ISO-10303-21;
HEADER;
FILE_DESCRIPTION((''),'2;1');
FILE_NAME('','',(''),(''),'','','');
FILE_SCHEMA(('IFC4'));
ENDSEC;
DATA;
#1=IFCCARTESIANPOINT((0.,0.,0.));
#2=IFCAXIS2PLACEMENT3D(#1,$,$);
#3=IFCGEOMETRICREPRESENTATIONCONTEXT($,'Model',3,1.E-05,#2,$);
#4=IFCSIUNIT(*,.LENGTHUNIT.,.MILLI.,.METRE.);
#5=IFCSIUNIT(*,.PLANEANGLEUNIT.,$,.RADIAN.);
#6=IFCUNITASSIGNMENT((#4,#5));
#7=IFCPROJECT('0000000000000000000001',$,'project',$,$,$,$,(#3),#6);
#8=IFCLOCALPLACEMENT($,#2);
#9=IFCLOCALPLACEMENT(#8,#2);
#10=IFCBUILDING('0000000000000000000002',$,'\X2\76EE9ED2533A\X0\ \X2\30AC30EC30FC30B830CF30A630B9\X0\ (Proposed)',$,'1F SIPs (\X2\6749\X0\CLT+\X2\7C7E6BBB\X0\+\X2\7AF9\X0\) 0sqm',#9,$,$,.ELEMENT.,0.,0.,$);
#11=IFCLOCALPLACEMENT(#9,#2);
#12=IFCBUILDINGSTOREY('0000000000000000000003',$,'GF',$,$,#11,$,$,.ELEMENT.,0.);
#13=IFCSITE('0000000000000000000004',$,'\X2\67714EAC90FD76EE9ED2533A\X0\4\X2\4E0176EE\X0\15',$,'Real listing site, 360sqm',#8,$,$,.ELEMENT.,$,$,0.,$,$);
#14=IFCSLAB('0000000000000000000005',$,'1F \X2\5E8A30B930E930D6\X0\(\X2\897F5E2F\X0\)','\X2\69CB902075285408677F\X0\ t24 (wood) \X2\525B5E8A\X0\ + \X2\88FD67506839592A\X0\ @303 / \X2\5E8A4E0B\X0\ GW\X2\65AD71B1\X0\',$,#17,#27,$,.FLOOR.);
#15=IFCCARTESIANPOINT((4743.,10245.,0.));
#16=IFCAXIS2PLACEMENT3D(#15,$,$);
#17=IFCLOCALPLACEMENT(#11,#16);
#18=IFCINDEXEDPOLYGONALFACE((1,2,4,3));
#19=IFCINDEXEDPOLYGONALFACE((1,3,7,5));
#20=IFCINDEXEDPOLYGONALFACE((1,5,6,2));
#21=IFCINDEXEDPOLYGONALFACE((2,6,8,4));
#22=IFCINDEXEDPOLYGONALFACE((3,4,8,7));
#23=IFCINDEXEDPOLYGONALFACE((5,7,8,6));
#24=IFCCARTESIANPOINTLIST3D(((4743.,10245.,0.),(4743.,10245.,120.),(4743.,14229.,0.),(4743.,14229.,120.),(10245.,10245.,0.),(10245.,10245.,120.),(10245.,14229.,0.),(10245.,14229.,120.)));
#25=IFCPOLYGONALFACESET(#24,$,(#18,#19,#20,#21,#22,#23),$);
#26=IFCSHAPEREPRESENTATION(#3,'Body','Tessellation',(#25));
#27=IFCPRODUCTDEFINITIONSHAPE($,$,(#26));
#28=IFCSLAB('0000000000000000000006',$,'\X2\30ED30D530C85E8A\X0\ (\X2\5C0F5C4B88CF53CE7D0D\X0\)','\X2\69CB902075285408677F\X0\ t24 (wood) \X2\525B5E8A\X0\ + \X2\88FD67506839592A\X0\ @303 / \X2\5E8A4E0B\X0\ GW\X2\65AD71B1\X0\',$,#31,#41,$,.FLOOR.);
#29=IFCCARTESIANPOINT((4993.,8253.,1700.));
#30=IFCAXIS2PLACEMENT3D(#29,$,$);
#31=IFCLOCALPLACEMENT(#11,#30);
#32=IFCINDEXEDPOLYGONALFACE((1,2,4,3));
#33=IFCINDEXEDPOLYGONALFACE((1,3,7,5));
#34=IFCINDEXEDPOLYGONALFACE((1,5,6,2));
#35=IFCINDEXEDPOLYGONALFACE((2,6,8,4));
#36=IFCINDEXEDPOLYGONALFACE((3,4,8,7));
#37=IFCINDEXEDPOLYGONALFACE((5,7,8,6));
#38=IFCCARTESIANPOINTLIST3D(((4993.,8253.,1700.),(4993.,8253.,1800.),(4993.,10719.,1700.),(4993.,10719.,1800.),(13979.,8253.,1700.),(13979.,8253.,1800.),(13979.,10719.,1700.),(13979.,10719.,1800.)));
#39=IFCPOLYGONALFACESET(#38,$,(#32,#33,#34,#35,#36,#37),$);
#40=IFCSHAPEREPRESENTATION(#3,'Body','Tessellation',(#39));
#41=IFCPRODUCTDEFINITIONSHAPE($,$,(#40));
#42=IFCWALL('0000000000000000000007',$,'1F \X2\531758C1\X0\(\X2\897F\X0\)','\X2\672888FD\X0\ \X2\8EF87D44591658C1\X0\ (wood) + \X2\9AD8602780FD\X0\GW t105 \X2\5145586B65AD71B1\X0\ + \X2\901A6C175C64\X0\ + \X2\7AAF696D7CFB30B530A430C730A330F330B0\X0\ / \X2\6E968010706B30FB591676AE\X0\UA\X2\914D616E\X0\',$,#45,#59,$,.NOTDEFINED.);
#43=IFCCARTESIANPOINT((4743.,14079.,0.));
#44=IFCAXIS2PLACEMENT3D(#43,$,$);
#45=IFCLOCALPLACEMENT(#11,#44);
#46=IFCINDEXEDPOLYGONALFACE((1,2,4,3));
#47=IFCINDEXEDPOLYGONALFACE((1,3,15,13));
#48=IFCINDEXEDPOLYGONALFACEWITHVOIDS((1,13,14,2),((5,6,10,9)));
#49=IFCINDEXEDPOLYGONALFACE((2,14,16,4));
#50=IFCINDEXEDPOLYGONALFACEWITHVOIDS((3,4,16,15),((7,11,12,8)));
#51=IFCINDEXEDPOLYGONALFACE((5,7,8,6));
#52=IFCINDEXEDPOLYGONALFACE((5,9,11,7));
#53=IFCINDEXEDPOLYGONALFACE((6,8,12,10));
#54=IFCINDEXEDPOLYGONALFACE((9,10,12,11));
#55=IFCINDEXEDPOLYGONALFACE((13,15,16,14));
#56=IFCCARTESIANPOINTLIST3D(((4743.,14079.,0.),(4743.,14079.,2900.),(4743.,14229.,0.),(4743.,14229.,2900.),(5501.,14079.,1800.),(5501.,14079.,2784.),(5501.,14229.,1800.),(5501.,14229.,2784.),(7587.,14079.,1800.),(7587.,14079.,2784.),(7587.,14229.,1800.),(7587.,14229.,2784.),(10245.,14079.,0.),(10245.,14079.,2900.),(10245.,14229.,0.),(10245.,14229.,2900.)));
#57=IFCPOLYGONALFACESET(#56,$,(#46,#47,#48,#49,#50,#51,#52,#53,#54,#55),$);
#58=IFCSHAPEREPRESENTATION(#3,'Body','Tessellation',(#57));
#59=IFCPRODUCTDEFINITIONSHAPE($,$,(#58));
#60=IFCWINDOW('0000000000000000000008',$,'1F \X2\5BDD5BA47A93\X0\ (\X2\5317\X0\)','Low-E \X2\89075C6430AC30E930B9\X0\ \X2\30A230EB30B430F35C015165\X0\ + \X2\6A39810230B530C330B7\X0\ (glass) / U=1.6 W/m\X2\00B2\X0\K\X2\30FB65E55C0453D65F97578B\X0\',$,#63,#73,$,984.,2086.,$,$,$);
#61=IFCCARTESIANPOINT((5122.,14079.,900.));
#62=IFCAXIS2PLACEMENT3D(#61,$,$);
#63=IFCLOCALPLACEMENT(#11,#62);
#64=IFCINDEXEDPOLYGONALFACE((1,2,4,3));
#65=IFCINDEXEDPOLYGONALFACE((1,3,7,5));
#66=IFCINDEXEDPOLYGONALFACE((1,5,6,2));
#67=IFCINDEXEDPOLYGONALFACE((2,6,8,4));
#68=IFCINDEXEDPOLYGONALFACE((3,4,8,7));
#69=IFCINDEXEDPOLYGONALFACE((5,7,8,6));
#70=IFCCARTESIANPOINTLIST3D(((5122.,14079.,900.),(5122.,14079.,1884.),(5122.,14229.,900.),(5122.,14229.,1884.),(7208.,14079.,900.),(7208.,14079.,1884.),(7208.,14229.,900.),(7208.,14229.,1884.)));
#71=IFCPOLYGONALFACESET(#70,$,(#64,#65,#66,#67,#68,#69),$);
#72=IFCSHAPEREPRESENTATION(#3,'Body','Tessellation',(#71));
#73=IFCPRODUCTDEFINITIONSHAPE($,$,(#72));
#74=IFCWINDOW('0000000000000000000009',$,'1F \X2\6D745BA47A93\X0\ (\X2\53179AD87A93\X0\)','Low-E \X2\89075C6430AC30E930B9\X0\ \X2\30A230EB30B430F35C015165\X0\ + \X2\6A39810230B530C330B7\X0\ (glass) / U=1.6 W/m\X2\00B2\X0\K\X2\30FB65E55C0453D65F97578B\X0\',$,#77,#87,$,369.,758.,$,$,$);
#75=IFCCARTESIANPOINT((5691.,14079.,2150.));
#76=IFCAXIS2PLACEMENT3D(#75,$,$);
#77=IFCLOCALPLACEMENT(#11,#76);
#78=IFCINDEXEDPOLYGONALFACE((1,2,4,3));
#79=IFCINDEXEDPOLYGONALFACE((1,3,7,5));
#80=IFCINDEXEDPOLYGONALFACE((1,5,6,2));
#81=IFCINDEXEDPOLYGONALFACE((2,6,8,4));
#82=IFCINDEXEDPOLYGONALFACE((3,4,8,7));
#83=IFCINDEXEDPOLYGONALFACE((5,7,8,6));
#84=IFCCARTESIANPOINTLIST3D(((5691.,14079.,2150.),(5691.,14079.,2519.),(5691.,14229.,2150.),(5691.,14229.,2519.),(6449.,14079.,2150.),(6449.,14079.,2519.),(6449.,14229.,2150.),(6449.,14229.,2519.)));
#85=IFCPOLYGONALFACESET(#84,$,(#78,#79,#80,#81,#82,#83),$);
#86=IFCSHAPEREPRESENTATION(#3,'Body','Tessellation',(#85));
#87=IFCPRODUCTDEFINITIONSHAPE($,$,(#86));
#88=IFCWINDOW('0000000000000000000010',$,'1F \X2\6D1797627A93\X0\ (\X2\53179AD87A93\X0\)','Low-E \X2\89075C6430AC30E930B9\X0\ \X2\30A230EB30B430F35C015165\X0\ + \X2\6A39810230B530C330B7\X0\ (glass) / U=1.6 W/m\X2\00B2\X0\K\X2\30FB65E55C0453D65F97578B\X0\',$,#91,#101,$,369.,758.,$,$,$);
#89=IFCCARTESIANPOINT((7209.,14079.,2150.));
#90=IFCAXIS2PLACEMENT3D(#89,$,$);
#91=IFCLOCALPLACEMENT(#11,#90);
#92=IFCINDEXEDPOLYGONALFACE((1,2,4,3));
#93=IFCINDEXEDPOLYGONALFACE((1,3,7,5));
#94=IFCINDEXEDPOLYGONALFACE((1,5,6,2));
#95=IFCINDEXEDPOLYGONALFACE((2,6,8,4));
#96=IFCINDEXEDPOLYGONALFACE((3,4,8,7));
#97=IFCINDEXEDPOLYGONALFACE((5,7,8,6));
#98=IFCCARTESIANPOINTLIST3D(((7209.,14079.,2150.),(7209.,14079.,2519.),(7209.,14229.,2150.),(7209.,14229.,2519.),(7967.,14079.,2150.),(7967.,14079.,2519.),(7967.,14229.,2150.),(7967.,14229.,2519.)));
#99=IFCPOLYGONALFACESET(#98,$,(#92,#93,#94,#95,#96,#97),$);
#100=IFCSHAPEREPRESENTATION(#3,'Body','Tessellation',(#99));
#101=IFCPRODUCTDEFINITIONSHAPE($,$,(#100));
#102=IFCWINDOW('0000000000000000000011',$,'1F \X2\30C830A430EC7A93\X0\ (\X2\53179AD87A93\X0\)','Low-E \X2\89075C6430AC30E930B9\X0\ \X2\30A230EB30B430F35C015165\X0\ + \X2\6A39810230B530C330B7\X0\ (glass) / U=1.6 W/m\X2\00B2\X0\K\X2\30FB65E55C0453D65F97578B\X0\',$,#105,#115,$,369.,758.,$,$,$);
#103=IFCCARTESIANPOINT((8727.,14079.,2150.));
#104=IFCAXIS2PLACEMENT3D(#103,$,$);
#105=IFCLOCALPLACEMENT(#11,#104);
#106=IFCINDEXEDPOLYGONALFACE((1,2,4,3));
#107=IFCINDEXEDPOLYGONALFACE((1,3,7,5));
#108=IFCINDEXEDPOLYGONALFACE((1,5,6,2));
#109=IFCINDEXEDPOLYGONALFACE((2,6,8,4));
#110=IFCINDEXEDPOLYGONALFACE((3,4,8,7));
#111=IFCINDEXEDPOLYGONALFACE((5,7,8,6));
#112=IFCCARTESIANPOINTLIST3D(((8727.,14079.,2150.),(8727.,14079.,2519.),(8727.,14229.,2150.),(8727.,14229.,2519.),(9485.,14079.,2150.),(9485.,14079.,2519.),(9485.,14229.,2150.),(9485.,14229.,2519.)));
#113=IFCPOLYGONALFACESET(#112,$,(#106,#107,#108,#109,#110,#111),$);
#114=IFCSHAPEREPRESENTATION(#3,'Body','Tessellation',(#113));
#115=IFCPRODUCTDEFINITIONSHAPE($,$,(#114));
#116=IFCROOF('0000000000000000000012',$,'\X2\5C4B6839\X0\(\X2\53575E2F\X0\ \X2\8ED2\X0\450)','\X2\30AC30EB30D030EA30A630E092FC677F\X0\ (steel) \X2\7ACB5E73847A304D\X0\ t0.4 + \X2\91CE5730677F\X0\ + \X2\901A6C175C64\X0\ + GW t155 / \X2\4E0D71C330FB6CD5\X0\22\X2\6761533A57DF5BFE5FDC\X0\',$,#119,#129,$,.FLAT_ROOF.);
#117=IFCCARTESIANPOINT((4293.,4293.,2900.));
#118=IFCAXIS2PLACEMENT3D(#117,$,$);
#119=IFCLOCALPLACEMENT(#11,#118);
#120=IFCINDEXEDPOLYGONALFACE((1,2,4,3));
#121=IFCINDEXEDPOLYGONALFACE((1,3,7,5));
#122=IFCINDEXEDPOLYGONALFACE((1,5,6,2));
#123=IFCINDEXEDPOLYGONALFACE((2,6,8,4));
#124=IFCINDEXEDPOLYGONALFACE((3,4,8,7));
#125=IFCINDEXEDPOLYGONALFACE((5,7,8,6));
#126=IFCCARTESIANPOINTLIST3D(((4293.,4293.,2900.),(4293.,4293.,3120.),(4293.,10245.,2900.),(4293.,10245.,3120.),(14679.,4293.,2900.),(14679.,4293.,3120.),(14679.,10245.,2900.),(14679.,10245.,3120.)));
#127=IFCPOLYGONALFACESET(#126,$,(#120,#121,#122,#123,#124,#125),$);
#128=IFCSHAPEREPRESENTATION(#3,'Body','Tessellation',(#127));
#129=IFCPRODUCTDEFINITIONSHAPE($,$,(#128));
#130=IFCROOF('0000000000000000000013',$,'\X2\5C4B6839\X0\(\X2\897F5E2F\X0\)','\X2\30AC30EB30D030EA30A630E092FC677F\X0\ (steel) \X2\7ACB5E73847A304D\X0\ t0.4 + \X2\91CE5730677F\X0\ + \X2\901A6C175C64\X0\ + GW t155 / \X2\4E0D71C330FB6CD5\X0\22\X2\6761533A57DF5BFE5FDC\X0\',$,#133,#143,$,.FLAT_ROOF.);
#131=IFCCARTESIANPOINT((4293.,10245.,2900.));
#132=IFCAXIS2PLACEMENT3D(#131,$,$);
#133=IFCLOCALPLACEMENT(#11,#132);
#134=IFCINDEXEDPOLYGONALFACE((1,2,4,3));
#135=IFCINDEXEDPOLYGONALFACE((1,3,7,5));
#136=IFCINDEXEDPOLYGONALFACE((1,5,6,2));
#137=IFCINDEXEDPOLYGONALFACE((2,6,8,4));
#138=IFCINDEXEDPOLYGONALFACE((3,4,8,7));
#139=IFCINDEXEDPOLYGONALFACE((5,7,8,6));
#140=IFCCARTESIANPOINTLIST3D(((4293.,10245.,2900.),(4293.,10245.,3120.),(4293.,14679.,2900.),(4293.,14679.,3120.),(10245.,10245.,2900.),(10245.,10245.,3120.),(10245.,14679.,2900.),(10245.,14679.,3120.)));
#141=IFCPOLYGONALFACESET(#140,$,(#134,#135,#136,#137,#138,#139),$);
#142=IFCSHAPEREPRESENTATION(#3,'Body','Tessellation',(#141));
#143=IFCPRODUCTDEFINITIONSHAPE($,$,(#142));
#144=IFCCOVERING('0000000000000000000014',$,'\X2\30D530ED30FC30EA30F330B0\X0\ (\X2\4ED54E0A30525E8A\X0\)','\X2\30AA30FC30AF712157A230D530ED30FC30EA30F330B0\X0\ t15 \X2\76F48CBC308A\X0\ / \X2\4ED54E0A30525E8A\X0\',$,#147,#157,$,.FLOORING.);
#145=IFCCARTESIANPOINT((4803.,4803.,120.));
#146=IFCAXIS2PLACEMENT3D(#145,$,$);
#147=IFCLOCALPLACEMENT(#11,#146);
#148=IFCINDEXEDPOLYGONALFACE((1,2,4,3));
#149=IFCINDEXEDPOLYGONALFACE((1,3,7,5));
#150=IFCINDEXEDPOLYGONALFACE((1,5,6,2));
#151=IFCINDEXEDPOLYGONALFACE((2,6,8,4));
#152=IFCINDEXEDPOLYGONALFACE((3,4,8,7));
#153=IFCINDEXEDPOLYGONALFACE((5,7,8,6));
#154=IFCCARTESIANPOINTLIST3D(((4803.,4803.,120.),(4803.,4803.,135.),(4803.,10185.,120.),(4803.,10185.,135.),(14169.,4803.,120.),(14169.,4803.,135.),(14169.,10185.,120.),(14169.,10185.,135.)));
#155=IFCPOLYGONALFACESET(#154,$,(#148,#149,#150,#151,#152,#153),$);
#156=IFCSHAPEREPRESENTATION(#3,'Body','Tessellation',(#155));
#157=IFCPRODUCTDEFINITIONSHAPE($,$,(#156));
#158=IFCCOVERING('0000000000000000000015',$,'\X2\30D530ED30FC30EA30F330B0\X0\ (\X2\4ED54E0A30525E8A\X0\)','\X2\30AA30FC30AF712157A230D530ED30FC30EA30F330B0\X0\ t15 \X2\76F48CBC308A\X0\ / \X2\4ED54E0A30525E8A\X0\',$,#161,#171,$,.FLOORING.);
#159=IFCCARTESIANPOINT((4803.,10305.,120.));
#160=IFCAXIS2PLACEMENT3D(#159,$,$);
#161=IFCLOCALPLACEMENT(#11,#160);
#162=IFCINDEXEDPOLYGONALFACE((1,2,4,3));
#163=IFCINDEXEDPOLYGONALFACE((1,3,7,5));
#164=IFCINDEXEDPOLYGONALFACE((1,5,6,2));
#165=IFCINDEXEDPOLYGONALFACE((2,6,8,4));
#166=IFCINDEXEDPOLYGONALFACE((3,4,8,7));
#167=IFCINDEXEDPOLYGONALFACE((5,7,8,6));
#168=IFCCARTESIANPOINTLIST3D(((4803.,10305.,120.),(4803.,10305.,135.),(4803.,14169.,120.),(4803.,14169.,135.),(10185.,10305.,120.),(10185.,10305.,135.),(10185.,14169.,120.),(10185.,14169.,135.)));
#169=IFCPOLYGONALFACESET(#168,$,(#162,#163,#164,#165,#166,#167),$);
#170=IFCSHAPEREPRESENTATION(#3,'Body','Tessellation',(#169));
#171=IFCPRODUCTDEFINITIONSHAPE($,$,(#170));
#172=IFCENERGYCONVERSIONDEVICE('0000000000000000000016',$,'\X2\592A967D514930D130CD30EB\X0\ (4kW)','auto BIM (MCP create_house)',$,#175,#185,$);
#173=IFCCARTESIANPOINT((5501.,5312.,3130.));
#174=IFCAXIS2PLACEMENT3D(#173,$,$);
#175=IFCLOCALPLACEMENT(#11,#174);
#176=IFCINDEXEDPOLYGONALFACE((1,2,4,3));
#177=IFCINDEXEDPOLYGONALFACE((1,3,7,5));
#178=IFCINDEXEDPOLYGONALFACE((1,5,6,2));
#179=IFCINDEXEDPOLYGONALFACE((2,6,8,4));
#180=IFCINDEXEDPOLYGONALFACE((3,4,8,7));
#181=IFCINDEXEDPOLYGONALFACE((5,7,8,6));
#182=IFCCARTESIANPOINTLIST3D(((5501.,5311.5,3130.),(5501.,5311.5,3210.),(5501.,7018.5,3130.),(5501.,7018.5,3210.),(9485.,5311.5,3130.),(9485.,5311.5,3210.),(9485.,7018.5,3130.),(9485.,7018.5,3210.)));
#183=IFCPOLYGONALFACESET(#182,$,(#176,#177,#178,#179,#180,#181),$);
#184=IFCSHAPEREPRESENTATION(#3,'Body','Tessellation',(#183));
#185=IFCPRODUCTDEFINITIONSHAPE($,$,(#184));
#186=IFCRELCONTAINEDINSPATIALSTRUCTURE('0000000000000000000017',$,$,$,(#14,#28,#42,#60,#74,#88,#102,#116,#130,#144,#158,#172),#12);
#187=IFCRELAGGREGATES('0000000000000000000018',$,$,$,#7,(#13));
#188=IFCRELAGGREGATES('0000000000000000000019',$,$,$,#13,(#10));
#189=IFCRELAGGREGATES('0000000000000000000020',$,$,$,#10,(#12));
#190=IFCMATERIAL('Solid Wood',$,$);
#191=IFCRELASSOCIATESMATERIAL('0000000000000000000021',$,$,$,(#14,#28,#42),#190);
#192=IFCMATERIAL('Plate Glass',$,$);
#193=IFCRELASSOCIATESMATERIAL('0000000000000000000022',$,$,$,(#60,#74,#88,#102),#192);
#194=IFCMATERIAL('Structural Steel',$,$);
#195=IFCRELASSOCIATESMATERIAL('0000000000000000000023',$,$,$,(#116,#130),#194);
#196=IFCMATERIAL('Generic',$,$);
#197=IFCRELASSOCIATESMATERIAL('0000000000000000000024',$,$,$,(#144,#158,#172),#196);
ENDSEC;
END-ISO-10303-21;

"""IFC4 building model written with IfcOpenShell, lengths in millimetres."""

from ifc_helpers import new_model, si_unit, frame, frame_2d, origin, place, context, project, spatial, rectangle, extrude, material, element, fill, save


model = new_model("IFC4")

# Units and contexts
model_context = context("Model", 3, precision=1e-05, world=origin())
ifc_project = project(units=[si_unit("LENGTHUNIT", "METRE", prefix="MILLI"), si_unit("PLANEANGLEUNIT", "RADIAN")], contexts=[model_context])

# Site, building, storey
site_placement = place(None, origin())
site = spatial("IfcSite", under=ifc_project, at=site_placement, Name="東京都目黒区4丁目15", ObjectType="Real listing site, 360sqm", CompositionType="ELEMENT", RefElevation=0.0)
building_placement = place(site_placement, origin())
building = spatial("IfcBuilding", under=site, at=building_placement, Name="目黒区 ガレージハウス (Proposed)", ObjectType="1F SIPs (杉CLT+籾殻+竹) 0sqm", CompositionType="ELEMENT", ElevationOfRefHeight=0.0, ElevationOfTerrain=0.0)
storey_placement = place(building_placement, origin())
storey = spatial("IfcBuildingStorey", under=building, at=storey_placement, Name="GF", CompositionType="ELEMENT", Elevation=0.0)

# Slabs
ifc_material_1 = material(Name="Solid Wood")
slab_1_placement = place(storey_placement, frame((4743.0, 10245.0, 0.0)))
element("IfcSlab", 1, at=slab_1_placement, inside=storey, material=ifc_material_1, Name="1F 床スラブ(西帯)", Description="構造用合板 t24 (wood) 剛床 + 製材根太 @303 / 床下 GW断熱", PredefinedType="FLOOR", context=model_context, shape_type="SweptSolid", body=[
    extrude(rectangle(XDim=5502.0, YDim=3984.0, at=frame_2d((2751.0, 1992.0))), frame((4743.0, 10245.0, 0.0)), (0.0, 0.0, 1.0), 120.0),
])
slab_2_placement = place(storey_placement, frame((4993.0, 8253.0, 1700.0)))
element("IfcSlab", 2, at=slab_2_placement, inside=storey, material=ifc_material_1, Name="ロフト床 (小屋裏収納)", Description="構造用合板 t24 (wood) 剛床 + 製材根太 @303 / 床下 GW断熱", PredefinedType="FLOOR", context=model_context, shape_type="SweptSolid", body=[
    extrude(rectangle(XDim=8986.0, YDim=2466.0, at=frame_2d((4493.0, 1233.0))), frame((4993.0, 8253.0, 1700.0)), (0.0, 0.0, 1.0), 100.0),
])

# Shared definitions
ifc_material_2 = material(Name="Plate Glass")

# Wall, openings, windows
wall_1_placement = place(storey_placement, frame((4743.0, 14079.0, 0.0)))
wall_1 = element("IfcWall", 3, at=wall_1_placement, inside=storey, material=ifc_material_1, Name="1F 北壁(西)", Description="木製 軸組外壁 (wood) + 高性能GW t105 充填断熱 + 通気層 + 窯業系サイディング / 準耐火・外皮UA配慮", PredefinedType="NOTDEFINED", context=model_context, shape_type="SweptSolid", body=[
    extrude(rectangle(XDim=5502.0, YDim=150.0, at=frame_2d((2751.0, 75.0))), frame((4743.0, 14079.0, 0.0)), (0.0, 0.0, 1.0), 2900.0),
])
opening_1_placement = place(storey_placement, frame((5122.0, 14079.0, 900.0)))
opening_1 = element("IfcOpeningElement", 4, at=opening_1_placement, cuts=wall_1, PredefinedType="NOTDEFINED", context=model_context, shape_type="SweptSolid", body=[
    extrude(rectangle(XDim=2086.0, YDim=150.0, at=frame_2d((1043.0, 75.0))), frame((5122.0, 14079.0, 900.0)), (0.0, 0.0, 1.0), 984.0),
])
opening_2_placement = place(storey_placement, frame((5691.0, 14079.0, 2150.0)))
opening_2 = element("IfcOpeningElement", 5, at=opening_2_placement, cuts=wall_1, PredefinedType="NOTDEFINED", context=model_context, shape_type="SweptSolid", body=[
    extrude(rectangle(XDim=758.0, YDim=150.0, at=frame_2d((379.0, 75.0))), frame((5691.0, 14079.0, 2150.0)), (0.0, 0.0, 1.0), 369.0),
])
opening_3_placement = place(storey_placement, frame((7209.0, 14079.0, 2150.0)))
opening_3 = element("IfcOpeningElement", 6, at=opening_3_placement, cuts=wall_1, PredefinedType="NOTDEFINED", context=model_context, shape_type="SweptSolid", body=[
    extrude(rectangle(XDim=758.0, YDim=150.0, at=frame_2d((379.0, 75.0))), frame((7209.0, 14079.0, 2150.0)), (0.0, 0.0, 1.0), 369.0),
])
opening_4_placement = place(storey_placement, frame((8727.0, 14079.0, 2150.0)))
opening_4 = element("IfcOpeningElement", 7, at=opening_4_placement, cuts=wall_1, PredefinedType="NOTDEFINED", context=model_context, shape_type="SweptSolid", body=[
    extrude(rectangle(XDim=758.0, YDim=150.0, at=frame_2d((379.0, 75.0))), frame((8727.0, 14079.0, 2150.0)), (0.0, 0.0, 1.0), 369.0),
])
window_1_placement = place(storey_placement, frame((5122.0, 14079.0, 900.0)))
window_1 = element("IfcWindow", 8, at=window_1_placement, inside=storey, material=ifc_material_2, Name="1F 寝室窓 (北)", Description="Low-E 複層ガラス アルゴン封入 + 樹脂サッシ (glass) / U=1.6 W/m²K・日射取得型", OverallHeight=984.0, OverallWidth=2086.0, context=model_context, shape_type="SweptSolid", body=[
    extrude(rectangle(XDim=2086.0, YDim=150.0, at=frame_2d((1043.0, 75.0))), frame((5122.0, 14079.0, 900.0)), (0.0, 0.0, 1.0), 984.0),
])
fill(opening_1, window_1)
window_2_placement = place(storey_placement, frame((5691.0, 14079.0, 2150.0)))
window_2 = element("IfcWindow", 9, at=window_2_placement, inside=storey, material=ifc_material_2, Name="1F 浴室窓 (北高窓)", Description="Low-E 複層ガラス アルゴン封入 + 樹脂サッシ (glass) / U=1.6 W/m²K・日射取得型", OverallHeight=369.0, OverallWidth=758.0, context=model_context, shape_type="SweptSolid", body=[
    extrude(rectangle(XDim=758.0, YDim=150.0, at=frame_2d((379.0, 75.0))), frame((5691.0, 14079.0, 2150.0)), (0.0, 0.0, 1.0), 369.0),
])
fill(opening_2, window_2)
window_3_placement = place(storey_placement, frame((7209.0, 14079.0, 2150.0)))
window_3 = element("IfcWindow", 10, at=window_3_placement, inside=storey, material=ifc_material_2, Name="1F 洗面窓 (北高窓)", Description="Low-E 複層ガラス アルゴン封入 + 樹脂サッシ (glass) / U=1.6 W/m²K・日射取得型", OverallHeight=369.0, OverallWidth=758.0, context=model_context, shape_type="SweptSolid", body=[
    extrude(rectangle(XDim=758.0, YDim=150.0, at=frame_2d((379.0, 75.0))), frame((7209.0, 14079.0, 2150.0)), (0.0, 0.0, 1.0), 369.0),
])
fill(opening_3, window_3)
window_4_placement = place(storey_placement, frame((8727.0, 14079.0, 2150.0)))
window_4 = element("IfcWindow", 11, at=window_4_placement, inside=storey, material=ifc_material_2, Name="1F トイレ窓 (北高窓)", Description="Low-E 複層ガラス アルゴン封入 + 樹脂サッシ (glass) / U=1.6 W/m²K・日射取得型", OverallHeight=369.0, OverallWidth=758.0, context=model_context, shape_type="SweptSolid", body=[
    extrude(rectangle(XDim=758.0, YDim=150.0, at=frame_2d((379.0, 75.0))), frame((8727.0, 14079.0, 2150.0)), (0.0, 0.0, 1.0), 369.0),
])
fill(opening_4, window_4)

# Roofs
ifc_material_3 = material(Name="Structural Steel")
roof_1_placement = place(storey_placement, frame((4293.0, 4293.0, 2900.0)))
element("IfcRoof", 12, at=roof_1_placement, inside=storey, material=ifc_material_3, Name="屋根(南帯 軒450)", Description="ガルバリウム鋼板 (steel) 立平葺き t0.4 + 野地板 + 通気層 + GW t155 / 不燃・法22条区域対応", PredefinedType="FLAT_ROOF", context=model_context, shape_type="SweptSolid", body=[
    extrude(rectangle(XDim=10386.0, YDim=5952.0, at=frame_2d((5193.0, 2976.0))), frame((4293.0, 4293.0, 2900.0)), (0.0, 0.0, 1.0), 220.0),
])
roof_2_placement = place(storey_placement, frame((4293.0, 10245.0, 2900.0)))
element("IfcRoof", 13, at=roof_2_placement, inside=storey, material=ifc_material_3, Name="屋根(西帯)", Description="ガルバリウム鋼板 (steel) 立平葺き t0.4 + 野地板 + 通気層 + GW t155 / 不燃・法22条区域対応", PredefinedType="FLAT_ROOF", context=model_context, shape_type="SweptSolid", body=[
    extrude(rectangle(XDim=5952.0, YDim=4434.0, at=frame_2d((2976.0, 2217.0))), frame((4293.0, 10245.0, 2900.0)), (0.0, 0.0, 1.0), 220.0),
])

# Coverings
ifc_material_4 = material(Name="Generic")
covering_1_placement = place(storey_placement, frame((4803.0, 4803.0, 120.0)))
element("IfcCovering", 14, at=covering_1_placement, inside=storey, material=ifc_material_4, Name="フローリング (仕上げ床)", Description="オーク無垢フローリング t15 直貼り / 仕上げ床", PredefinedType="FLOORING", context=model_context, shape_type="SweptSolid", body=[
    extrude(rectangle(XDim=9366.0, YDim=5382.0, at=frame_2d((4683.0, 2691.0))), frame((4803.0, 4803.0, 120.0)), (0.0, 0.0, 1.0), 15.0),
])
covering_2_placement = place(storey_placement, frame((4803.0, 10305.0, 120.0)))
element("IfcCovering", 15, at=covering_2_placement, inside=storey, material=ifc_material_4, Name="フローリング (仕上げ床)", Description="オーク無垢フローリング t15 直貼り / 仕上げ床", PredefinedType="FLOORING", context=model_context, shape_type="SweptSolid", body=[
    extrude(rectangle(XDim=5382.0, YDim=3864.0, at=frame_2d((2691.0, 1932.0))), frame((4803.0, 10305.0, 120.0)), (0.0, 0.0, 1.0), 15.0),
])

# Energy conversion device
energy_conversion_device_placement = place(storey_placement, frame((5501.0, 5312.0, 3130.0)))
element("IfcEnergyConversionDevice", 16, at=energy_conversion_device_placement, inside=storey, material=ifc_material_4, Name="太陽光パネル (4kW)", Description="auto BIM (MCP create_house)", context=model_context, shape_type="SweptSolid", body=[
    extrude(rectangle(XDim=3984.0, YDim=1707.0, at=frame_2d((1992.0, 853.0))), frame((5501.0, 5312.0, 3130.0)), (0.0, 0.0, 1.0), 80.0),
])

save(model, "model.ifc")
